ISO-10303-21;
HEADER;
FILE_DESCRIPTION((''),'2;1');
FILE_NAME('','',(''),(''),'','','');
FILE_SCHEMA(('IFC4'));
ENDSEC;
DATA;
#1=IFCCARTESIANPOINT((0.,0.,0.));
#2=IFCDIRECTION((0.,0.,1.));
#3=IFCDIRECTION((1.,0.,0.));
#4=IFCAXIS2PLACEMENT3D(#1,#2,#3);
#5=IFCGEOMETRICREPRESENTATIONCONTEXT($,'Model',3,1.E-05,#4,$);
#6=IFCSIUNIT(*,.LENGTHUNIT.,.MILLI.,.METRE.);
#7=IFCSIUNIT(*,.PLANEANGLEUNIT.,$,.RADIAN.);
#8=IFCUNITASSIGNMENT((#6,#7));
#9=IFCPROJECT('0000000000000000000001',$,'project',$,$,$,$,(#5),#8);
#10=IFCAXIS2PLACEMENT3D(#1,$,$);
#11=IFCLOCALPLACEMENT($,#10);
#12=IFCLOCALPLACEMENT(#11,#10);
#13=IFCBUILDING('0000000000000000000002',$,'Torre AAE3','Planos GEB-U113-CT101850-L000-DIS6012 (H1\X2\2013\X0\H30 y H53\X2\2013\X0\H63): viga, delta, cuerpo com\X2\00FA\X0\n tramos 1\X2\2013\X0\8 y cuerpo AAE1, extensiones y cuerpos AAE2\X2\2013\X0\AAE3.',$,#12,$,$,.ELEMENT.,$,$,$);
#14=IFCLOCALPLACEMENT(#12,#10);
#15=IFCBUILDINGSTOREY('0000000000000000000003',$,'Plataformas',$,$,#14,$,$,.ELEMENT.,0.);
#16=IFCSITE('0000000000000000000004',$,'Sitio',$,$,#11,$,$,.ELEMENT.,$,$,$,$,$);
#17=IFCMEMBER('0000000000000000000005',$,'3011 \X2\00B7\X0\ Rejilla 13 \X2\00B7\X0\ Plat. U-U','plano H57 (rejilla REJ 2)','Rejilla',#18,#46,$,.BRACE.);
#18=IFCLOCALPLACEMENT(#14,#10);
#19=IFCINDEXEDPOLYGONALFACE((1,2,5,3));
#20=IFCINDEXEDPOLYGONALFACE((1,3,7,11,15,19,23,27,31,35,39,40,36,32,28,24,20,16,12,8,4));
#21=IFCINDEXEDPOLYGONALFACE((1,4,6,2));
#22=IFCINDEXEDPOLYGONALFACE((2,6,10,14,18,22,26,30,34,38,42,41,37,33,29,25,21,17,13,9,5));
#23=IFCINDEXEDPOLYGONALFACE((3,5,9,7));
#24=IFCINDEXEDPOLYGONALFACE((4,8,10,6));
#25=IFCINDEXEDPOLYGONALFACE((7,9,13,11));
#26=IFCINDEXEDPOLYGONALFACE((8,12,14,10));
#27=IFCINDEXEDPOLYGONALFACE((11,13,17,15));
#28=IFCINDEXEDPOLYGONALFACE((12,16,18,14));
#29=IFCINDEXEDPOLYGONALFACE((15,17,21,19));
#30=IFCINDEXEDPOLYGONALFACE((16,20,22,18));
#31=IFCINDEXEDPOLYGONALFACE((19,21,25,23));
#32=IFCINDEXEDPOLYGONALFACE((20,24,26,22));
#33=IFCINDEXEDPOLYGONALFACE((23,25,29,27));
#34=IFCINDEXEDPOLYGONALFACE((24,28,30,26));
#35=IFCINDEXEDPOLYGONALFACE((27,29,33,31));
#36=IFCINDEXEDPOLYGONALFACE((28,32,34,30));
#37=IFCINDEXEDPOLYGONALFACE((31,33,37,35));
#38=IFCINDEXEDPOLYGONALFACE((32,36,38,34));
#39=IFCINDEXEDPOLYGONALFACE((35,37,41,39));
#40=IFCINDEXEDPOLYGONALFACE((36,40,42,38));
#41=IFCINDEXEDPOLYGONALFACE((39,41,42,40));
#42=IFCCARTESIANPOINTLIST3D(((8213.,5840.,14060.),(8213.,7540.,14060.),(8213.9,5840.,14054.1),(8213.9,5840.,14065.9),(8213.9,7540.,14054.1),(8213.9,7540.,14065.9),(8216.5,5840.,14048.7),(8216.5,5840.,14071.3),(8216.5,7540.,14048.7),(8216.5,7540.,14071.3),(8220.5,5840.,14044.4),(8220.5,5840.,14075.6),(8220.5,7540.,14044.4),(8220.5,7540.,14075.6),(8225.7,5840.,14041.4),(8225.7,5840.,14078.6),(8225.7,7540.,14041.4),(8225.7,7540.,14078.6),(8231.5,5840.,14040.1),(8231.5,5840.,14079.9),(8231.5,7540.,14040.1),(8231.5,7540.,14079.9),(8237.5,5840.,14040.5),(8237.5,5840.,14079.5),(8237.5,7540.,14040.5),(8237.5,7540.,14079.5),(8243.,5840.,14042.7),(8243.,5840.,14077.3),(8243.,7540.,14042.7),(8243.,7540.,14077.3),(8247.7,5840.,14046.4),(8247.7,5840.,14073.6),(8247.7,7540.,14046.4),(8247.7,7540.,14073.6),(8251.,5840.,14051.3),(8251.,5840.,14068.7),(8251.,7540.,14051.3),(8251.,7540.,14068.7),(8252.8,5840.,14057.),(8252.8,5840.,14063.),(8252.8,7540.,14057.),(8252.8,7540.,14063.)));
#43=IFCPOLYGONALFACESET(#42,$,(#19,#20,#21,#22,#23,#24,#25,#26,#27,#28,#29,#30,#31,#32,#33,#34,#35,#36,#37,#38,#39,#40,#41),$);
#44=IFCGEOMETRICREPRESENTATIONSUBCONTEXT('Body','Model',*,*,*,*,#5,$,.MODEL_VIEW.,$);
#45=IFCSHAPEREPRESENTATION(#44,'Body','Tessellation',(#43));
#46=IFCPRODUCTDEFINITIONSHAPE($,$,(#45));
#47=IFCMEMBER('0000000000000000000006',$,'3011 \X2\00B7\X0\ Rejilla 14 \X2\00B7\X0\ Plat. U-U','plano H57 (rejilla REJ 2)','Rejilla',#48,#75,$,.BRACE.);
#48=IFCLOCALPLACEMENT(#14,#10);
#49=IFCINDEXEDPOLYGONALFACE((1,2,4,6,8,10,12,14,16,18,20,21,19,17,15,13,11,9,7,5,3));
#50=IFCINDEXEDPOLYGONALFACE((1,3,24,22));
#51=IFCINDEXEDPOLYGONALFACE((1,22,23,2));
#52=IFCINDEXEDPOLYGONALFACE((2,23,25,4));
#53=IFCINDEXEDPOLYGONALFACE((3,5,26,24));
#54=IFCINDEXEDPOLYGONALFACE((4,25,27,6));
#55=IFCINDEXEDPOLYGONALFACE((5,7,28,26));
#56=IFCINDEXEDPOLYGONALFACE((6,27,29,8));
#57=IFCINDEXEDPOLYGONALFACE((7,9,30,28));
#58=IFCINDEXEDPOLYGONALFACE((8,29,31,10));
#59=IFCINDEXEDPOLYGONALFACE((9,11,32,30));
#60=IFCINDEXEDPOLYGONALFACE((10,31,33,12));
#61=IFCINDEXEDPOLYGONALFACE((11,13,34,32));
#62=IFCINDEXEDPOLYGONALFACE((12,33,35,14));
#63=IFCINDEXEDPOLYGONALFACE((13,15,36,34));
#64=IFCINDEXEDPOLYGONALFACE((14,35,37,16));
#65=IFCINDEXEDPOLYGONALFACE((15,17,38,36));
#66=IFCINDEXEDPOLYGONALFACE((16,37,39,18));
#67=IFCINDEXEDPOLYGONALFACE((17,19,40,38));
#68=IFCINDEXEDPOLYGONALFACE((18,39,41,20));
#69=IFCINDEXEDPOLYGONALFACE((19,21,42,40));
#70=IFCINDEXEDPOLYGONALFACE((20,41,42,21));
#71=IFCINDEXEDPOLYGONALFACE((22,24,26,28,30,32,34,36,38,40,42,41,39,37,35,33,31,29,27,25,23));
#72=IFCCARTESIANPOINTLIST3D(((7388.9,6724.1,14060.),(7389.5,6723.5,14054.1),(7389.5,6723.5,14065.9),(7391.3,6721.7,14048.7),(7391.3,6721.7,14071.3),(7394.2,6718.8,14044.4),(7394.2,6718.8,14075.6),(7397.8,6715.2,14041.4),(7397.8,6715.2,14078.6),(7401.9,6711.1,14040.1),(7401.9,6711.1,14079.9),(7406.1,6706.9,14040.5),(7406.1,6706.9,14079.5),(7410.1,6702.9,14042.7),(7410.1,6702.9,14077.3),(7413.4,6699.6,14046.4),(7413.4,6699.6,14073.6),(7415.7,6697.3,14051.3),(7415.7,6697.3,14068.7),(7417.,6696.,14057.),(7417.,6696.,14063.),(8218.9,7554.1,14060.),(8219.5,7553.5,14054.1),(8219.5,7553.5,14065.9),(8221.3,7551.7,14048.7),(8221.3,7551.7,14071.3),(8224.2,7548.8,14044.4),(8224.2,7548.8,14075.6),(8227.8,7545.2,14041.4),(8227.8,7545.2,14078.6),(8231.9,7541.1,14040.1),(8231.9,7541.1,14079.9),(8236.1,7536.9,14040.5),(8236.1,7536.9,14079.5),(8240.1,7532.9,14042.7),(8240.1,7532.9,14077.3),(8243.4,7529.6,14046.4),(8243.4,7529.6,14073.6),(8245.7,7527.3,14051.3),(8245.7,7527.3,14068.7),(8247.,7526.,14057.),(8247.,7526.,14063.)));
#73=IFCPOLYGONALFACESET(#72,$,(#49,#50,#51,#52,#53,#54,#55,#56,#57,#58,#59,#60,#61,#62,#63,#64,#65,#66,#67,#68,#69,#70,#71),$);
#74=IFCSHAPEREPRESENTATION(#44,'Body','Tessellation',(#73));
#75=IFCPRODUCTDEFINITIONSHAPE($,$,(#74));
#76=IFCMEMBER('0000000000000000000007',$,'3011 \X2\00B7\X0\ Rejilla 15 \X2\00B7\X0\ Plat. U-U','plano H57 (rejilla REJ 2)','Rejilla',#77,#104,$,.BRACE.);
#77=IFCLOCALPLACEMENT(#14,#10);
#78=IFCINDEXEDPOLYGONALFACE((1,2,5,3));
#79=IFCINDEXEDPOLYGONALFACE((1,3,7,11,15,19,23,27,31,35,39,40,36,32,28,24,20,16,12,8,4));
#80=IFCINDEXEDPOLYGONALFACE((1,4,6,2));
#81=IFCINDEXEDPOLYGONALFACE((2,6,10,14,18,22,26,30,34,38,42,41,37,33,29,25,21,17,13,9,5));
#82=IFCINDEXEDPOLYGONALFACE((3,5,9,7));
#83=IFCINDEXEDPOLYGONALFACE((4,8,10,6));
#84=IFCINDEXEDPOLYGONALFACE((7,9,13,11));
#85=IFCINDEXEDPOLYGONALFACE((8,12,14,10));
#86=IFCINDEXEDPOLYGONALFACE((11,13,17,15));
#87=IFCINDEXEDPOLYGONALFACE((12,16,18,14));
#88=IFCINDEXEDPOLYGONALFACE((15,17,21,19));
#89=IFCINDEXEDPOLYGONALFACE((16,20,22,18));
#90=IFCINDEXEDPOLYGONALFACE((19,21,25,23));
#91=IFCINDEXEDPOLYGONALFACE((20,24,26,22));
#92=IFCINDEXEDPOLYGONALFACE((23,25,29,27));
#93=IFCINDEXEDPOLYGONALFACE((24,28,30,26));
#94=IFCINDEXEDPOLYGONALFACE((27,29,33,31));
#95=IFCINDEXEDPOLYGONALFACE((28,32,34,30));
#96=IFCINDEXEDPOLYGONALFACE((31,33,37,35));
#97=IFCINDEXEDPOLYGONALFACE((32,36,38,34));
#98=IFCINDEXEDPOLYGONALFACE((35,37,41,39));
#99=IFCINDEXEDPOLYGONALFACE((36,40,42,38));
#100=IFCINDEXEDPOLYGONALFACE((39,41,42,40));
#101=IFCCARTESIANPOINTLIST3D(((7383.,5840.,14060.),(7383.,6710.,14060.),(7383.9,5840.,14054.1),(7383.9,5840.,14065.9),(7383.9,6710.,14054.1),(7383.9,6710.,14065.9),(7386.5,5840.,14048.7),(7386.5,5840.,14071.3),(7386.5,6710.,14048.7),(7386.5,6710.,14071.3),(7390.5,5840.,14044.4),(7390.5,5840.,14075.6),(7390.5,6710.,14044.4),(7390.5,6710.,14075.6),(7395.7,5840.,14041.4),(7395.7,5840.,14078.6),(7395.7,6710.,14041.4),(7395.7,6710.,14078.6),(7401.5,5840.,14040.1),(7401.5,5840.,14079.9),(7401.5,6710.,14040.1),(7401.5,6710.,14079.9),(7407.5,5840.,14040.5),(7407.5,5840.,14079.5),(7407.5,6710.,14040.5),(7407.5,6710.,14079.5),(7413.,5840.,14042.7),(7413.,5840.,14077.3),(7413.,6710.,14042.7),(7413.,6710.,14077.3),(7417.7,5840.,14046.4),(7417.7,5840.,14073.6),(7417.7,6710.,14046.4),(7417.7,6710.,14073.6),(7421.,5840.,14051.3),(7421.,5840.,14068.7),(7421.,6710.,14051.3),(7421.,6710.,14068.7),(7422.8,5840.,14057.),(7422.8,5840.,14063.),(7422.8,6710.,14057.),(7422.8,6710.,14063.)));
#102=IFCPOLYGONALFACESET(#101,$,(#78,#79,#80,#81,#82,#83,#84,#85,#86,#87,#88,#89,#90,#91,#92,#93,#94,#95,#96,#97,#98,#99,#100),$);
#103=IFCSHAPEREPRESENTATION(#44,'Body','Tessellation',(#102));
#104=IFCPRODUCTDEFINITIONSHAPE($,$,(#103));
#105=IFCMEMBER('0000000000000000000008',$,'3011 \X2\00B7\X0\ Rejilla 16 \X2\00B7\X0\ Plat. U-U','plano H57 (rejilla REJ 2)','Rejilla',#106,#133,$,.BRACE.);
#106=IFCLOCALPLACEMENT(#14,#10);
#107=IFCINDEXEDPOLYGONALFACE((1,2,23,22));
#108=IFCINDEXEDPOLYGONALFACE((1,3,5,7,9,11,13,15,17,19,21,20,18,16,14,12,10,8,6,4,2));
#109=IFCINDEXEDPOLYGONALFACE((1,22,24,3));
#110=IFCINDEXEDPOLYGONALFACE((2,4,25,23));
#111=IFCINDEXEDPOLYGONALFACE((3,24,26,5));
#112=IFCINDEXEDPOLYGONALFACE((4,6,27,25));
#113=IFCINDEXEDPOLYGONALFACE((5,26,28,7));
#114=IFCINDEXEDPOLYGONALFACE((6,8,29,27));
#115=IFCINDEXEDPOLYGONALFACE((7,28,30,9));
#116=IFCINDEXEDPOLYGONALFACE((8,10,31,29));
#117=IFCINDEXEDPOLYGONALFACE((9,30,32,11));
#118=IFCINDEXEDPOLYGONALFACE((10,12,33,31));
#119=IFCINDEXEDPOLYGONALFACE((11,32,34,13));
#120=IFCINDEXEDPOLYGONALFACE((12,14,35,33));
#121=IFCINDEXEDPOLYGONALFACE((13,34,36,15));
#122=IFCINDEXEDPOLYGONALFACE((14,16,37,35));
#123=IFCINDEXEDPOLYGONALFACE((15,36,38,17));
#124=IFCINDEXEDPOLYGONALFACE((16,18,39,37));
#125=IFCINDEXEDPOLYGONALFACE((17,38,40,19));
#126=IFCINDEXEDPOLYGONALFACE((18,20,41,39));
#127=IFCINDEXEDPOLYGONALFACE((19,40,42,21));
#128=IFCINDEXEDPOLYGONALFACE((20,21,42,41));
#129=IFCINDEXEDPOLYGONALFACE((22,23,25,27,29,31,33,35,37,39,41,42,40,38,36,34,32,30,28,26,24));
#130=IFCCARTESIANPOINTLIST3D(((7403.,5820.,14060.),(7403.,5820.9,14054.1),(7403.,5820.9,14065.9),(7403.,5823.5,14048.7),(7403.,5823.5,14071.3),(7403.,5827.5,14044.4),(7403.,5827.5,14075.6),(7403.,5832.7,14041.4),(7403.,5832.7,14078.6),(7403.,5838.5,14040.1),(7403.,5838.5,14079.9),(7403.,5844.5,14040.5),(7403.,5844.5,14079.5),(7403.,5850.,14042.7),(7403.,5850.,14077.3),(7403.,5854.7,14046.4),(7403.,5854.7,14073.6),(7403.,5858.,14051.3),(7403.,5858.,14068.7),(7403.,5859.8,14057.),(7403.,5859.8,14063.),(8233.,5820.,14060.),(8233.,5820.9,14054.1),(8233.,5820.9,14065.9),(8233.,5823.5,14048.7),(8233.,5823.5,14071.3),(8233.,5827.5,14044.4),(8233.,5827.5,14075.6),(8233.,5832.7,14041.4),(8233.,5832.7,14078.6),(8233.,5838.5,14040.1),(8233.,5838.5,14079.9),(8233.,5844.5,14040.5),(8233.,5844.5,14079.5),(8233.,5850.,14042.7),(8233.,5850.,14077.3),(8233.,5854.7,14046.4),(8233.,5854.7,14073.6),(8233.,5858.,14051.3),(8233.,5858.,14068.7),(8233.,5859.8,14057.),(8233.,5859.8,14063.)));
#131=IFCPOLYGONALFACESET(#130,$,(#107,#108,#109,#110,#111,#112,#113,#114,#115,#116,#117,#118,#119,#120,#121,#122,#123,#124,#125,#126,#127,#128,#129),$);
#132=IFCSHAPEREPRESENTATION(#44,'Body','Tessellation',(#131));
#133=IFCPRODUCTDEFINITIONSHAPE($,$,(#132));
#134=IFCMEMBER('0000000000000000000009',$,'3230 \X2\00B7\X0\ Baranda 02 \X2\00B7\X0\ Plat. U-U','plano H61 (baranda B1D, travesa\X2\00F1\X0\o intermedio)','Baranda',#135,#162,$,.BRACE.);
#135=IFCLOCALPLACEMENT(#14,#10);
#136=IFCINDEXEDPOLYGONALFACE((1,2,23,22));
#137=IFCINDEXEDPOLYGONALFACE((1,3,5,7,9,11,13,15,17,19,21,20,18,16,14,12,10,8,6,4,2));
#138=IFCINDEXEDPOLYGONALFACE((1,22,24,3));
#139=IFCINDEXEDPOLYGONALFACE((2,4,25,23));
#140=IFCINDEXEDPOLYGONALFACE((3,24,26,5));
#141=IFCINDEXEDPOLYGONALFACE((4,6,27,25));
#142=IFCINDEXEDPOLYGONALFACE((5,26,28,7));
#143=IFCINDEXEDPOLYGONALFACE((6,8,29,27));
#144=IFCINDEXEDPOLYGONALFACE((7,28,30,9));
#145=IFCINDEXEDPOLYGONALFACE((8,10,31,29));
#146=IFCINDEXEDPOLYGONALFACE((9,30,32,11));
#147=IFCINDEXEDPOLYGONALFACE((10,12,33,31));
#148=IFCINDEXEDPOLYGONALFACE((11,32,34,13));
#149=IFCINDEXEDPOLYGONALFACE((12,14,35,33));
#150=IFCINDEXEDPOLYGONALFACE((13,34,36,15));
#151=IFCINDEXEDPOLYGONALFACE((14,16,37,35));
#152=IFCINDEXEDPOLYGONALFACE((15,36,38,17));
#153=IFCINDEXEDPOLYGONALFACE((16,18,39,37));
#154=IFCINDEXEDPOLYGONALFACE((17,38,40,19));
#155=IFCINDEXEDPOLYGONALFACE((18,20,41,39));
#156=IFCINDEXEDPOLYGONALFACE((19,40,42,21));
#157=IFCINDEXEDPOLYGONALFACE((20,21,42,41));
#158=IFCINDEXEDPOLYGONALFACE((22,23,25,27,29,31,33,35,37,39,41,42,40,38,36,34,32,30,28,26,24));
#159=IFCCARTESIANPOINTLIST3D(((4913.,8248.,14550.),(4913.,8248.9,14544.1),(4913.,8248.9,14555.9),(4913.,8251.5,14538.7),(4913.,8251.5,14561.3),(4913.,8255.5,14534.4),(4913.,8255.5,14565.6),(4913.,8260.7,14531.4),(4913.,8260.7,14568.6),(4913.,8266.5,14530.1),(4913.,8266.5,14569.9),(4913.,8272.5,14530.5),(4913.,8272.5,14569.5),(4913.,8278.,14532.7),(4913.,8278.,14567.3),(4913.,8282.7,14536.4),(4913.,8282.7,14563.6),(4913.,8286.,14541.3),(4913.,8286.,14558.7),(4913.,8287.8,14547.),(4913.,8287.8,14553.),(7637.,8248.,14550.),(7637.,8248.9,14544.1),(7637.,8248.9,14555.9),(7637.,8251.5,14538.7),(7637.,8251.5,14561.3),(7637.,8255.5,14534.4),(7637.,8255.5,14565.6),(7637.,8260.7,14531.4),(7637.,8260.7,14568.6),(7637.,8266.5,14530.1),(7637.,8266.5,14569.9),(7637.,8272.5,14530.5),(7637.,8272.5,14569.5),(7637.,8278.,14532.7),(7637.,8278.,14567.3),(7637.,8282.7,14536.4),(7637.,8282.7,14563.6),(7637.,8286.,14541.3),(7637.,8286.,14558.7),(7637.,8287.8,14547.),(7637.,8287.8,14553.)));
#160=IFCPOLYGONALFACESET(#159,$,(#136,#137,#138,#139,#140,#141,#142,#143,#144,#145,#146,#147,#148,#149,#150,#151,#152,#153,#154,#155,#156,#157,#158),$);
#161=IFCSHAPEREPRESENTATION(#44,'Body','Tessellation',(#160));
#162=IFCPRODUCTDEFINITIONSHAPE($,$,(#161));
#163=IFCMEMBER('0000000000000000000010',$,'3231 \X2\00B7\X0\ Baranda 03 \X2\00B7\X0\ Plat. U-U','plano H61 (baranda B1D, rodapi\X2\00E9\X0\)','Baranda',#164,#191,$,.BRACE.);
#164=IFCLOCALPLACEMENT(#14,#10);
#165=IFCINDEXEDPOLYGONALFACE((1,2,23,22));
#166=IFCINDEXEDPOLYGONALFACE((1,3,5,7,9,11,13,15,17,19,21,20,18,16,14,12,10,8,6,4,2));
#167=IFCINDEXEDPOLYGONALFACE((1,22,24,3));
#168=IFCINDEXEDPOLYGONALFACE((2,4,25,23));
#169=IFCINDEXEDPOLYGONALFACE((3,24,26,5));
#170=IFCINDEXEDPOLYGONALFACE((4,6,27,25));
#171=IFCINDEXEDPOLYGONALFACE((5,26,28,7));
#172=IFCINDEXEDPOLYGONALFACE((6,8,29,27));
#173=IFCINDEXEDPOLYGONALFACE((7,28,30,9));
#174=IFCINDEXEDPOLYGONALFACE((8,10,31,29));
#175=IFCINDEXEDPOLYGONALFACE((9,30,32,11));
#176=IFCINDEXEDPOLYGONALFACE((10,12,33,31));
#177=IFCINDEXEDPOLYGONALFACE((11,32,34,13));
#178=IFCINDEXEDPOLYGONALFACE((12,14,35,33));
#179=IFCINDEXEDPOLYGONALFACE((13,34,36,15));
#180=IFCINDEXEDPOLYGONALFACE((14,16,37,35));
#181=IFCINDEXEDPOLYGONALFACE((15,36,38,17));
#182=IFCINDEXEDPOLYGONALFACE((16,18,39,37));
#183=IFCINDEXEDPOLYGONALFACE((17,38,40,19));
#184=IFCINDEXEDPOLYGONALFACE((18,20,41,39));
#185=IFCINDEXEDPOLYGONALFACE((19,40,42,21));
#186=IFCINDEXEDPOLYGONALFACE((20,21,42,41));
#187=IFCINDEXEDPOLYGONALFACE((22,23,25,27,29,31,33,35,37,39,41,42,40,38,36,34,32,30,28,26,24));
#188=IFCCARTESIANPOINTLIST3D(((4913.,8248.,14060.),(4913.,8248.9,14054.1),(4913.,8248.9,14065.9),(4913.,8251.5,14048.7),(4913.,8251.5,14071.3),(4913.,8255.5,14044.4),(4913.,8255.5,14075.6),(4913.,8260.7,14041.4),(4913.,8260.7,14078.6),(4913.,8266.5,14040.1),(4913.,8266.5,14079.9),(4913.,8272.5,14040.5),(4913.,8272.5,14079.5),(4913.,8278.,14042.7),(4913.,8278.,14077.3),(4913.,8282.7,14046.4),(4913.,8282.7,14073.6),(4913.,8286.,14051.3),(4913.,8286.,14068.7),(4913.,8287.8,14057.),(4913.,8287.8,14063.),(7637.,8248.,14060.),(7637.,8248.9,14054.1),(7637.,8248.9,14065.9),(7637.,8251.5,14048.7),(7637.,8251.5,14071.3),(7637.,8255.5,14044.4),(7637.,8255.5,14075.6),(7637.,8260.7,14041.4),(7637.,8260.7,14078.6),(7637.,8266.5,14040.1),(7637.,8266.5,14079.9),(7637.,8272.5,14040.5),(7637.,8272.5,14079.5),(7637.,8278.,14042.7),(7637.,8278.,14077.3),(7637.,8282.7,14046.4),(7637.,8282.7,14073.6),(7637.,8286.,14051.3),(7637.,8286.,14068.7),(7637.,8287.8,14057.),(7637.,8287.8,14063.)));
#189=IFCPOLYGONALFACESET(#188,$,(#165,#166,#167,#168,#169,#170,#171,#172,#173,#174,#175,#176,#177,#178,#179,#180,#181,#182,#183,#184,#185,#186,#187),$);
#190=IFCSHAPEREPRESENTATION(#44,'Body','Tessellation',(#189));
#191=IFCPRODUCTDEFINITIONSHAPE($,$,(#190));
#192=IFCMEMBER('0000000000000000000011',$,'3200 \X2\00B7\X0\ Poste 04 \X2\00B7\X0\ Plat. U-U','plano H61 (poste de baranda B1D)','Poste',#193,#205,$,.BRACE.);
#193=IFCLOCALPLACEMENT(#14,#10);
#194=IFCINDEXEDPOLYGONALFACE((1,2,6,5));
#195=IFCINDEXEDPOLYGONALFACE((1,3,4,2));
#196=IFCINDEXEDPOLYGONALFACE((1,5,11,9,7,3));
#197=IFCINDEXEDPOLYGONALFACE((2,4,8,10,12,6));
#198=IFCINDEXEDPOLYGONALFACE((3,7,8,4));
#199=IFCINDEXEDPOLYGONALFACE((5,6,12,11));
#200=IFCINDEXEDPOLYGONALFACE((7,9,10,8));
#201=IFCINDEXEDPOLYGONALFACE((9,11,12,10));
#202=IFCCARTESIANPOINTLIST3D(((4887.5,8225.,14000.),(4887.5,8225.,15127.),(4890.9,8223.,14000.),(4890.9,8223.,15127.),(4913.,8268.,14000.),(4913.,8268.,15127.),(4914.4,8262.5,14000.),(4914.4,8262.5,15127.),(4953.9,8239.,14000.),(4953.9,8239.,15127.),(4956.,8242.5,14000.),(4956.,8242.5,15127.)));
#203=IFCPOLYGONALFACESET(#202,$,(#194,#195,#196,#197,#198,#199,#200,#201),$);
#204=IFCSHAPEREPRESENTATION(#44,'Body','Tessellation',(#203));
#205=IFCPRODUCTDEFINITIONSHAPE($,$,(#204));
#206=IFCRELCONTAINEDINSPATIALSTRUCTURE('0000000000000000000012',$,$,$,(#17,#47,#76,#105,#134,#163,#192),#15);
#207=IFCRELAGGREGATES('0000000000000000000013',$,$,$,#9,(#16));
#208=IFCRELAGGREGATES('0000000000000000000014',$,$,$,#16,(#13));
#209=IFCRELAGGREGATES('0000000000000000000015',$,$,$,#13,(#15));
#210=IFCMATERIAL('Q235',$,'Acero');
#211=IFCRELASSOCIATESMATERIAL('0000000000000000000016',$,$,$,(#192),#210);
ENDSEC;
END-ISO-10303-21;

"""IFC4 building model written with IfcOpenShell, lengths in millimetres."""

from ifc_helpers import new_model, si_unit, frame, frame_2d, origin, origin_with_axes, place, context, subcontext, project, spatial, circle, l_section, extrude, material, element, save


model = new_model("IFC4")

# Units and contexts
model_context = context("Model", 3, precision=1e-05, world=origin_with_axes())
body_context = subcontext(model_context, "Body", "Model", "MODEL_VIEW")
ifc_project = project(units=[si_unit("LENGTHUNIT", "METRE", prefix="MILLI"), si_unit("PLANEANGLEUNIT", "RADIAN")], contexts=[model_context])

# Site, building, storey
site_placement = place(None, origin())
site = spatial("IfcSite", under=ifc_project, at=site_placement, Name="Sitio", CompositionType="ELEMENT")
building_placement = place(site_placement, origin())
building = spatial("IfcBuilding", under=site, at=building_placement, Name="Torre AAE3", Description="Planos GEB-U113-CT101850-L000-DIS6012 (H1–H30 y H53–H63): viga, delta, cuerpo común tramos 1–8 y cuerpo AAE1, extensiones y cuerpos AAE2–AAE3.", CompositionType="ELEMENT")
storey_placement = place(building_placement, origin())
storey = spatial("IfcBuildingStorey", under=building, at=storey_placement, Name="Plataformas", CompositionType="ELEMENT", Elevation=0.0)

# Members
member_1_placement = place(storey_placement, frame((8233.0, 5840.0, 14060.0), z_axis=(0.0, 1.0, 0.0), x_axis=(-1.0, 0.0, 0.0)))
element("IfcMember", 1, at=member_1_placement, inside=storey, Name="3011 · Rejilla 13 · Plat. U-U", Description="plano H57 (rejilla REJ 2)", ObjectType="Rejilla", PredefinedType="BRACE", context=body_context, shape_type="SweptSolid", body=[
    extrude(circle(Radius=20.0), None, (0.0, 0.0, 1.0), 1700.0),
])
member_2_placement = place(storey_placement, frame((8233.0, 7540.0, 14060.0), z_axis=(-0.707107, -0.707107, 0.0), x_axis=(-0.707107, 0.707107, 0.0)))
element("IfcMember", 2, at=member_2_placement, inside=storey, Name="3011 · Rejilla 14 · Plat. U-U", Description="plano H57 (rejilla REJ 2)", ObjectType="Rejilla", PredefinedType="BRACE", context=body_context, shape_type="SweptSolid", body=[
    extrude(circle(Radius=20.0), None, (0.0, 0.0, 1.0), 1173.8),
])
member_3_placement = place(storey_placement, frame((7403.0, 6710.0, 14060.0), z_axis=(0.0, -1.0, 0.0), x_axis=(-1.0, 0.0, 0.0)))
element("IfcMember", 3, at=member_3_placement, inside=storey, Name="3011 · Rejilla 15 · Plat. U-U", Description="plano H57 (rejilla REJ 2)", ObjectType="Rejilla", PredefinedType="BRACE", context=body_context, shape_type="SweptSolid", body=[
    extrude(circle(Radius=20.0), None, (0.0, 0.0, 1.0), 870.0),
])
member_4_placement = place(storey_placement, frame((7403.0, 5840.0, 14060.0), z_axis=(1.0, 0.0, 0.0), x_axis=(0.0, -1.0, 0.0)))
element("IfcMember", 4, at=member_4_placement, inside=storey, Name="3011 · Rejilla 16 · Plat. U-U", Description="plano H57 (rejilla REJ 2)", ObjectType="Rejilla", PredefinedType="BRACE", context=body_context, shape_type="SweptSolid", body=[
    extrude(circle(Radius=20.0), None, (0.0, 0.0, 1.0), 830.0),
])
for number, where, z_axis, x_axis, name, description in (
    (5, (7637.0, 8268.0, 14550.0), (-1.0, 0.0, 0.0), (0.0, -1.0, 0.0), "3230 · Baranda 02 · Plat. U-U", "plano H61 (baranda B1D, travesaño intermedio)"),
    (6, (7637.0, 8268.0, 14060.0), (-1.0, 0.0, 0.0), (0.0, -1.0, 0.0), "3231 · Baranda 03 · Plat. U-U", "plano H61 (baranda B1D, rodapié)"),
):
    element("IfcMember", number, at=place(storey_placement, frame(where, z_axis=z_axis, x_axis=x_axis)), inside=storey, Name=name, Description=description, ObjectType="Baranda", PredefinedType="BRACE", context=body_context, shape_type="SweptSolid", body=[
        extrude(circle(Radius=20.0), None, (0.0, 0.0, 1.0), 2724.0),
    ])
ifc_material = material(Name="Q235", Category="Acero")
member_5_placement = place(storey_placement, frame((4913.0, 8268.0, 14000.0), z_axis=(0.0, 0.0, 1.0), x_axis=(-0.510837, -0.859678, 0.0)))
element("IfcMember", 7, at=member_5_placement, inside=storey, material=ifc_material, Name="3200 · Poste 04 · Plat. U-U", Description="plano H61 (poste de baranda B1D)", ObjectType="Poste", PredefinedType="BRACE", context=body_context, shape_type="SweptSolid", body=[
    extrude(l_section(Depth=50.0, Width=50.0, Thickness=4.0, at=frame_2d((25.0, 25.0))), None, (0.0, 0.0, 1.0), 1127.0),
])

save(model, "model.ifc")
